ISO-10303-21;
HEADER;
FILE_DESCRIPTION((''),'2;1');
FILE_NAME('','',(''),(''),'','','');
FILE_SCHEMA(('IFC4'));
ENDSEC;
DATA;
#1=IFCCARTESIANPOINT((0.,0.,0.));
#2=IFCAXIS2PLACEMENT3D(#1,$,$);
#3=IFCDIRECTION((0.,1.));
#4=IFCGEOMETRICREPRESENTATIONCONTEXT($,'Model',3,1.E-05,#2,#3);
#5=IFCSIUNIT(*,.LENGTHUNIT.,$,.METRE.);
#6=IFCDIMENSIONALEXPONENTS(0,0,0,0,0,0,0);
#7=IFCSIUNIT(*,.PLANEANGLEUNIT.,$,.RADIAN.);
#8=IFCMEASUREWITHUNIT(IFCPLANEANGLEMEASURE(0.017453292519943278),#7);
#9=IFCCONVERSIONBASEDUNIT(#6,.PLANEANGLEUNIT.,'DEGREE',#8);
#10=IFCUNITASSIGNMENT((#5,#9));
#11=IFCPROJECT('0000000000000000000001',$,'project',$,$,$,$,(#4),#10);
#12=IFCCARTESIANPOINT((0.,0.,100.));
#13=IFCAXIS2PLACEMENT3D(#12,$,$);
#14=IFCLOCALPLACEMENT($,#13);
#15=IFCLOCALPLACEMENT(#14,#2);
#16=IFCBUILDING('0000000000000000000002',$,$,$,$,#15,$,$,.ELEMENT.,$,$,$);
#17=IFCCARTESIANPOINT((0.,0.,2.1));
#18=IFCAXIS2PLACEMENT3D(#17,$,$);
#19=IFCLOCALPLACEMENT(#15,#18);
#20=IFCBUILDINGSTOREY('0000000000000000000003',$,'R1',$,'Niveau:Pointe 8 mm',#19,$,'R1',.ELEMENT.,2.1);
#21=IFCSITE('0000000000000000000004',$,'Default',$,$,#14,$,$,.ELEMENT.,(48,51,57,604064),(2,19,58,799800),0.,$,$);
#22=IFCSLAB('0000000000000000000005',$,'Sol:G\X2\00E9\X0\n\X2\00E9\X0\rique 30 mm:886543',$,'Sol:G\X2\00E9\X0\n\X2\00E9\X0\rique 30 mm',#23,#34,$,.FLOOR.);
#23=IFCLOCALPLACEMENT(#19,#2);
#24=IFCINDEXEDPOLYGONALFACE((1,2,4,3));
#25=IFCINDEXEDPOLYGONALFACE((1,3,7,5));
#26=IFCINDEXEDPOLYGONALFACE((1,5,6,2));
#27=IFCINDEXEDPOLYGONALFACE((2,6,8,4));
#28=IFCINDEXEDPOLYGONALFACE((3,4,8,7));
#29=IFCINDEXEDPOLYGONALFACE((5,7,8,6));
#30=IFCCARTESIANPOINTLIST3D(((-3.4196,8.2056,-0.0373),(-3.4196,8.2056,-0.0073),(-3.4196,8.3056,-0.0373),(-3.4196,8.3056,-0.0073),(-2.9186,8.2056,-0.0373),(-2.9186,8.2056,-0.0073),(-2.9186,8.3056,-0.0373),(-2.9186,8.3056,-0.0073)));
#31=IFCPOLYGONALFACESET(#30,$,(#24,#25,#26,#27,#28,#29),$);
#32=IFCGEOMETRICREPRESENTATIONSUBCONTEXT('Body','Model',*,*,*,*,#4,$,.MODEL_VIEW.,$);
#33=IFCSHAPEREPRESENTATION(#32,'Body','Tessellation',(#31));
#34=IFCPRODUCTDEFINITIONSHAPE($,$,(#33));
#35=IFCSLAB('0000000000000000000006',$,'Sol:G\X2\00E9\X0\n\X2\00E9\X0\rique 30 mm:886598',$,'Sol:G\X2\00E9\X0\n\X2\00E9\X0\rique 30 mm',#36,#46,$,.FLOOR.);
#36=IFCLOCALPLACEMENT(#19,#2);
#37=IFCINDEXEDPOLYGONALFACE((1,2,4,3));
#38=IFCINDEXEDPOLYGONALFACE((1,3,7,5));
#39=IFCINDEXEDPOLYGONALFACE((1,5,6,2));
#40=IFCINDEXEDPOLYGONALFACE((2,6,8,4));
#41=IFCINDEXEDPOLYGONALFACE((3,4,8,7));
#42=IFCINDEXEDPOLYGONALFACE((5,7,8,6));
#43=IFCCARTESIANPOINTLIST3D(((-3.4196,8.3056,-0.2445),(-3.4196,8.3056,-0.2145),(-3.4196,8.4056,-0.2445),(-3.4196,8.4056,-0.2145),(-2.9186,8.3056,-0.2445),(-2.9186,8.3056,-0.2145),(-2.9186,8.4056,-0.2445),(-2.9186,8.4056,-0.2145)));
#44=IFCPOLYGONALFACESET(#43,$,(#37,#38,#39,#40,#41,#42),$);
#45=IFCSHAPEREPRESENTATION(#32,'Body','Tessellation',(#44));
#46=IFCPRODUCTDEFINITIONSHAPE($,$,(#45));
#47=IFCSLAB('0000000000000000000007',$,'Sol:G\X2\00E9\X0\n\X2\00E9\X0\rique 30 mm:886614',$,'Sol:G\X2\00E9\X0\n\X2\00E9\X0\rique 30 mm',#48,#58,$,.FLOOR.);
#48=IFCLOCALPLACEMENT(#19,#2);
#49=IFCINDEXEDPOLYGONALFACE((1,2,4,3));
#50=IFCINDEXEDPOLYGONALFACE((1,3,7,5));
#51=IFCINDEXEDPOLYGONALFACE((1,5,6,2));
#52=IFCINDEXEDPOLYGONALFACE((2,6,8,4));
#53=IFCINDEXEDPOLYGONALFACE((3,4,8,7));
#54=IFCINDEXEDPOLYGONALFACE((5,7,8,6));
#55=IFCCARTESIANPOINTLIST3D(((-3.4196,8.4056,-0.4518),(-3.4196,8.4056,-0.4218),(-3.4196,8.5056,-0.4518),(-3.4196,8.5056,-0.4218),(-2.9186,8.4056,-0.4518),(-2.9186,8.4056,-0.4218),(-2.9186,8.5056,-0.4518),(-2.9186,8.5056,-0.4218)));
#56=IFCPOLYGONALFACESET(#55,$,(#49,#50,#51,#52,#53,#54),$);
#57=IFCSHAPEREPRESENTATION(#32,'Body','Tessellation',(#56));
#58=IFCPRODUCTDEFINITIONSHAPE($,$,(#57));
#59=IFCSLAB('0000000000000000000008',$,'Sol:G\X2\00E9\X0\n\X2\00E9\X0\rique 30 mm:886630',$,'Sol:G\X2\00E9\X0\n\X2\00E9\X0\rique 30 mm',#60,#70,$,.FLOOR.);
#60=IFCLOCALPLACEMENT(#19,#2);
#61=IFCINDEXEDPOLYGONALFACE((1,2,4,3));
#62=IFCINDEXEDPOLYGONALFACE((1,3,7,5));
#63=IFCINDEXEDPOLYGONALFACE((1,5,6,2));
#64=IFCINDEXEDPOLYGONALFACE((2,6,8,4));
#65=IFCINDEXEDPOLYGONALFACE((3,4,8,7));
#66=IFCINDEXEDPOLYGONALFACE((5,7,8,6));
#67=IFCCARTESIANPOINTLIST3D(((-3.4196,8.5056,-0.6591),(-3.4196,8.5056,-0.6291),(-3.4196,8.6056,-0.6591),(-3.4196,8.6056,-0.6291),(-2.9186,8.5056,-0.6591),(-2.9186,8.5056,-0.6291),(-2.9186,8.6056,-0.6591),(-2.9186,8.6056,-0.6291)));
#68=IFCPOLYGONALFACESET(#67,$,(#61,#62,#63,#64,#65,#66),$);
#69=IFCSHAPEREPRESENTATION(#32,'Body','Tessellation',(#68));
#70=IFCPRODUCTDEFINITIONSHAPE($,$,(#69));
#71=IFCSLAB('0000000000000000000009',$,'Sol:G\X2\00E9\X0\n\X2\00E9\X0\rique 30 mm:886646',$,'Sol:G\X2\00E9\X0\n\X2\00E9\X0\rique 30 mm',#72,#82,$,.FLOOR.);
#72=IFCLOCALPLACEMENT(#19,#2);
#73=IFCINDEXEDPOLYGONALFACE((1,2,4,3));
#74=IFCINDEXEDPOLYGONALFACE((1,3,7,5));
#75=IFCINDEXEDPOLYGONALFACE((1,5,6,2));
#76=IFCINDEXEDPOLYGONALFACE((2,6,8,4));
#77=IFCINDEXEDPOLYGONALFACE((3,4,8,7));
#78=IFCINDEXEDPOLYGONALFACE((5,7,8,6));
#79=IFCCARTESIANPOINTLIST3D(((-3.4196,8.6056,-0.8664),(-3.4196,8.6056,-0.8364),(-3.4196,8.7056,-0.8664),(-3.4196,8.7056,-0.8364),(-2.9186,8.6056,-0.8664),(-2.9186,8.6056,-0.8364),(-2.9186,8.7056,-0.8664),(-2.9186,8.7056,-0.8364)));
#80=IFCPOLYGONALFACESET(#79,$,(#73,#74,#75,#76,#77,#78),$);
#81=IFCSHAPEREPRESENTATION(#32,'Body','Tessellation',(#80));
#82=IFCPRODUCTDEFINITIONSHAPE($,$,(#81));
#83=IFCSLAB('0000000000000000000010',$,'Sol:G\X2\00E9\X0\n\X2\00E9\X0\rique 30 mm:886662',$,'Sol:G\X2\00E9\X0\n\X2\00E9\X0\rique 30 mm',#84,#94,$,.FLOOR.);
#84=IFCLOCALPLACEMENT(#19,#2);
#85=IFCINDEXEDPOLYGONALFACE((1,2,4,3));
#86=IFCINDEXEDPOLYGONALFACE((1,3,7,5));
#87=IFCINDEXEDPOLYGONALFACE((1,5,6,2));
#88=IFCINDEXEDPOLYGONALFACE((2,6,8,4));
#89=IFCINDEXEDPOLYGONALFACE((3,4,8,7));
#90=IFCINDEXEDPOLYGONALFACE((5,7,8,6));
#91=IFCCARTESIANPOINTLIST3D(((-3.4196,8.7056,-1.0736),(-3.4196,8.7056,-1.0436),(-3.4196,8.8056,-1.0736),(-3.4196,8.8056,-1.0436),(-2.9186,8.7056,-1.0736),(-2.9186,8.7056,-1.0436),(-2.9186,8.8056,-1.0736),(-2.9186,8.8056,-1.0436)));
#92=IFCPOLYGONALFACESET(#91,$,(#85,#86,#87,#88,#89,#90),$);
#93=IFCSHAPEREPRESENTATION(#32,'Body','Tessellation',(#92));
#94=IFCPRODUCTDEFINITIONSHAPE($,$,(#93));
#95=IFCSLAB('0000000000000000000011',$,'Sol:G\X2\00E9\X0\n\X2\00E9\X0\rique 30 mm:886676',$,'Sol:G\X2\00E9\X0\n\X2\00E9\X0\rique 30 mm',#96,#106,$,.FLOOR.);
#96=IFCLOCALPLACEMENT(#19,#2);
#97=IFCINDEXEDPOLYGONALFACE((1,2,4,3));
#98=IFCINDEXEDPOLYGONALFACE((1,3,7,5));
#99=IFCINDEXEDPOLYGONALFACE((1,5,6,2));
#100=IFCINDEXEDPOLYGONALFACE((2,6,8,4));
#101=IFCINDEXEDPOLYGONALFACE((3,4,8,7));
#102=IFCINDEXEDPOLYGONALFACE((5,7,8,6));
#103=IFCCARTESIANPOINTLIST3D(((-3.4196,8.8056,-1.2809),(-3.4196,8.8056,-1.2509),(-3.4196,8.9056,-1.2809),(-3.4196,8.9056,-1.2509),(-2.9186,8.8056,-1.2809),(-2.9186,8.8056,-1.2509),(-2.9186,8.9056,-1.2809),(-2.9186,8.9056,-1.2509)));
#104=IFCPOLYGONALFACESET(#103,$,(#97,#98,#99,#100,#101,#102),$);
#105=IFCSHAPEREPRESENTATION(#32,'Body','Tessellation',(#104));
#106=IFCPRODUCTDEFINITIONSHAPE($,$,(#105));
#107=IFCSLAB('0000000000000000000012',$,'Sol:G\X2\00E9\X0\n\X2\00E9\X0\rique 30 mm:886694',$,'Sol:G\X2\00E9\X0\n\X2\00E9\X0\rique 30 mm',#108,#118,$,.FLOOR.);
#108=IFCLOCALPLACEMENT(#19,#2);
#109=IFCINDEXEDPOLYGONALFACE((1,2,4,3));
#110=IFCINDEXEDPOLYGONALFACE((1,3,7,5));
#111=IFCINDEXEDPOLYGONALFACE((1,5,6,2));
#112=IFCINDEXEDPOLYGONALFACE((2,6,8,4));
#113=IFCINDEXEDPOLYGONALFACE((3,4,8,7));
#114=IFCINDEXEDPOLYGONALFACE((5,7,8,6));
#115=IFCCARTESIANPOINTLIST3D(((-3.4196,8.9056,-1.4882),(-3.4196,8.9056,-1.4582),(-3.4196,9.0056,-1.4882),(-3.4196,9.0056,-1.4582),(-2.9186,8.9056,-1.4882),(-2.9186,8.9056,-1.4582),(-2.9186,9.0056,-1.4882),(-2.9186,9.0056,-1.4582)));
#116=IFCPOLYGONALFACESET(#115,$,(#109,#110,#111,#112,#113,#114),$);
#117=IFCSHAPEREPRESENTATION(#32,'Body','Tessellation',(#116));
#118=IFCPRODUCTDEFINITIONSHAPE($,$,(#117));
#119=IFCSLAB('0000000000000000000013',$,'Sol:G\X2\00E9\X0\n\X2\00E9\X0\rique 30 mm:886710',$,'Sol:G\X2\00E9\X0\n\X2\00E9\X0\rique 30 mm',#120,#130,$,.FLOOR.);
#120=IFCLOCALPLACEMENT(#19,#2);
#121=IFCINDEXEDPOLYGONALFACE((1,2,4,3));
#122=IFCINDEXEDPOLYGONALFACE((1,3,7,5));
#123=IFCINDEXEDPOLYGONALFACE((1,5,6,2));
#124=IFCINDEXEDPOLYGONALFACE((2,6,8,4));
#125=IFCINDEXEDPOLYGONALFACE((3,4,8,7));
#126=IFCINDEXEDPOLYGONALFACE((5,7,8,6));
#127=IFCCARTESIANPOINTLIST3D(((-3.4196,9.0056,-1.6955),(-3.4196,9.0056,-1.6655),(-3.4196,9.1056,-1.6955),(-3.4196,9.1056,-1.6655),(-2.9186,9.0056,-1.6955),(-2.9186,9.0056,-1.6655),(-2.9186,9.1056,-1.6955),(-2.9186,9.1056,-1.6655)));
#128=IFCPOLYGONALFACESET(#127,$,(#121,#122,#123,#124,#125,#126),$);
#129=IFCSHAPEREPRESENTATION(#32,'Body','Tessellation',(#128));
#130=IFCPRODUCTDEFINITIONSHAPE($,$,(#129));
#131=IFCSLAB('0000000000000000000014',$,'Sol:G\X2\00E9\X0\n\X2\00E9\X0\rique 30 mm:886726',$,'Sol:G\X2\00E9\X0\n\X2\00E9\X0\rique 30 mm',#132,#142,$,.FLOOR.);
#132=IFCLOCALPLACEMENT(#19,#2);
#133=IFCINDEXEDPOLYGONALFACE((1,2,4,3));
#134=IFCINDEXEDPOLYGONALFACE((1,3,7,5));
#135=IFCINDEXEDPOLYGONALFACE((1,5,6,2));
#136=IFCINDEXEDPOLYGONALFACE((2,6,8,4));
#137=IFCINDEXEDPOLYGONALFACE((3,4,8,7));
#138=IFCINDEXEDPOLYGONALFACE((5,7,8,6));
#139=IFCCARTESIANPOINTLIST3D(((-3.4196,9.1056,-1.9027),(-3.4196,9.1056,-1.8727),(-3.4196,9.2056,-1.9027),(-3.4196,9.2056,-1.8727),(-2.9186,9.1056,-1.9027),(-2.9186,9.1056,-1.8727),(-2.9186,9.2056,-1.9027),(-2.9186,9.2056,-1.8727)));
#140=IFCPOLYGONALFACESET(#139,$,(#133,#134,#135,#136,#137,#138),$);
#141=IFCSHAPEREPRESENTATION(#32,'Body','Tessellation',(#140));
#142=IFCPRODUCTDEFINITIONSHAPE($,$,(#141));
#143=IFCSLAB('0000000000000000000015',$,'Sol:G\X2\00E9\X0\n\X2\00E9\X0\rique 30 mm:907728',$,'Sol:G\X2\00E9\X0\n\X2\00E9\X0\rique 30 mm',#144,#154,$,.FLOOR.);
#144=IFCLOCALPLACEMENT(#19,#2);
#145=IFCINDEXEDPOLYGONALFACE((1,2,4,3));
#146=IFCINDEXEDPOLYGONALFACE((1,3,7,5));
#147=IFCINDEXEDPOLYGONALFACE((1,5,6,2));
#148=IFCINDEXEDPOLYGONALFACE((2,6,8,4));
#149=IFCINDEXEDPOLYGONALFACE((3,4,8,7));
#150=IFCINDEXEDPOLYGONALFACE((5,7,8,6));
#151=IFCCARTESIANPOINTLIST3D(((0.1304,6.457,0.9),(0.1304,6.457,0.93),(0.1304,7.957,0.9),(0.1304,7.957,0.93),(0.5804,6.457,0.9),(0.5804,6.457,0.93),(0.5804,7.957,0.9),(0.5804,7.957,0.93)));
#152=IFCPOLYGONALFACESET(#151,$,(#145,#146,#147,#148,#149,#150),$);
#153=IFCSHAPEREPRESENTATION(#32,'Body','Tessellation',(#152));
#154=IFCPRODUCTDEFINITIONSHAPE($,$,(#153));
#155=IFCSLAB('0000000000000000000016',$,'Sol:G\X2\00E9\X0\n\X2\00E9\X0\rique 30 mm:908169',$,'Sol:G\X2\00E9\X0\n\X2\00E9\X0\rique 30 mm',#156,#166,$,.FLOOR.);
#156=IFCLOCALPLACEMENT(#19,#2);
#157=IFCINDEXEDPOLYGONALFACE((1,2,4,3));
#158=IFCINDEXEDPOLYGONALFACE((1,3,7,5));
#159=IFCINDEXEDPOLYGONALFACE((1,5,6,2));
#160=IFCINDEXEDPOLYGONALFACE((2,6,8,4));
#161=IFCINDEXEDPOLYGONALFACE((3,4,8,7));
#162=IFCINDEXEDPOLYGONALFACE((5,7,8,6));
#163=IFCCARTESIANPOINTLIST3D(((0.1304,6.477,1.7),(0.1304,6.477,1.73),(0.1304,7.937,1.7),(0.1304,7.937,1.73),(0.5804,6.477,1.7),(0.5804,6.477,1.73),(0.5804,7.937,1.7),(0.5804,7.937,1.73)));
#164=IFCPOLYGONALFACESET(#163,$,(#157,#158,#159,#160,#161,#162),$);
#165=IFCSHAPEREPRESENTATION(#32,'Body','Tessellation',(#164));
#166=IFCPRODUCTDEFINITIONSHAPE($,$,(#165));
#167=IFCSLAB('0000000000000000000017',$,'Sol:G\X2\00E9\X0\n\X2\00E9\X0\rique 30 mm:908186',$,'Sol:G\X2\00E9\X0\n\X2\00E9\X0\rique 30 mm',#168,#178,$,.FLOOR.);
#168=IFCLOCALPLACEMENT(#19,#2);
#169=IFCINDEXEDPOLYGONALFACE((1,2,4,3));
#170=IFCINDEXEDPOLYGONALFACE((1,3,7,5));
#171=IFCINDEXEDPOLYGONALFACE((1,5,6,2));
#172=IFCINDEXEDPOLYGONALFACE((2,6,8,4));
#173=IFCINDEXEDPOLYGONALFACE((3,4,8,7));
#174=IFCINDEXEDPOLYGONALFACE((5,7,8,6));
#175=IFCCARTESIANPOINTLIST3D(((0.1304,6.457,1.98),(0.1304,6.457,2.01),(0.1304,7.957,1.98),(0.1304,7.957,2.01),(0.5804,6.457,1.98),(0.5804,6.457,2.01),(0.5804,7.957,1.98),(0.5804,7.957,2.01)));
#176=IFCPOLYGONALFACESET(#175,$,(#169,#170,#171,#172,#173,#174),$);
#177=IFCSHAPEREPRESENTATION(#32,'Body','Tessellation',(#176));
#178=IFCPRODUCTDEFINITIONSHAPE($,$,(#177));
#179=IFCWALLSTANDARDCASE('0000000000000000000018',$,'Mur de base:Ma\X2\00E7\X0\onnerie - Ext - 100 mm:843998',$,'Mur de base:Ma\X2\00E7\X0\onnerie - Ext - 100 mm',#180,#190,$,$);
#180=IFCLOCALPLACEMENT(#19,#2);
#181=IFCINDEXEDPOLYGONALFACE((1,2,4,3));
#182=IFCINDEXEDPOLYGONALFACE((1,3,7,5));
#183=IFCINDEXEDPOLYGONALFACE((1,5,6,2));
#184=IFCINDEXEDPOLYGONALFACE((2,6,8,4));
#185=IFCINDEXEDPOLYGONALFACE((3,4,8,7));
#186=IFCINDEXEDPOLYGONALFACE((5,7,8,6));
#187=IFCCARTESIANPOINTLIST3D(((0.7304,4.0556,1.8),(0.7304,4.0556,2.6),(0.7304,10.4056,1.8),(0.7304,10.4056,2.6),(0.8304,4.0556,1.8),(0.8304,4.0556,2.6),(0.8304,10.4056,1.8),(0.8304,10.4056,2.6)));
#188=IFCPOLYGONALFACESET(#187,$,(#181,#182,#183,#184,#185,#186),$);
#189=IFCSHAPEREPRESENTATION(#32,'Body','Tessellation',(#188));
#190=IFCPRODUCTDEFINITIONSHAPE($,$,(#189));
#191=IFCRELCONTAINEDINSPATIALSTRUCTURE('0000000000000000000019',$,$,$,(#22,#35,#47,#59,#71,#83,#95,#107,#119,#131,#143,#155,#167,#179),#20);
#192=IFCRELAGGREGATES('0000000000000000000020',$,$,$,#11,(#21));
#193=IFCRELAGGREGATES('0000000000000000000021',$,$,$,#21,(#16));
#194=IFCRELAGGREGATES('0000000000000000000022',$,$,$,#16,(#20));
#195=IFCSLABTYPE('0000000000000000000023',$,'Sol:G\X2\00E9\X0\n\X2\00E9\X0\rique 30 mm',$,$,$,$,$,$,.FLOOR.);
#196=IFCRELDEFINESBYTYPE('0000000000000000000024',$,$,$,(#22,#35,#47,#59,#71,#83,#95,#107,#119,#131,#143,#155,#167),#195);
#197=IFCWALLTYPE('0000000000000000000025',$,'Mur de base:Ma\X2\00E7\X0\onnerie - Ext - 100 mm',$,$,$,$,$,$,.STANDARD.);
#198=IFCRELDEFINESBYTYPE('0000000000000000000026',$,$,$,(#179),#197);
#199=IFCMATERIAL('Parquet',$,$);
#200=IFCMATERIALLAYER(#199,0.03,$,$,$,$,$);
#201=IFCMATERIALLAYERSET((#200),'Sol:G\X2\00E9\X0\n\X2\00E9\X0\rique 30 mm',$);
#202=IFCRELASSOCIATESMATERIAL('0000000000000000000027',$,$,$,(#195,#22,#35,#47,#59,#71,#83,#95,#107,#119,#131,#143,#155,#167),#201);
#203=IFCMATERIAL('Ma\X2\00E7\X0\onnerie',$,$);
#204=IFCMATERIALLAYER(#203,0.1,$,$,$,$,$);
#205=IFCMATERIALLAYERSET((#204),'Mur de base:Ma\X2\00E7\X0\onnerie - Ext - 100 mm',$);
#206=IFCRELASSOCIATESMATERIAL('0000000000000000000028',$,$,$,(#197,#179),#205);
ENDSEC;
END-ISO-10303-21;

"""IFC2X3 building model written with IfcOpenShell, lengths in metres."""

from ifc_helpers import new_model, entity, si_unit, converted_unit, direction, frame, frame_2d, origin, place, context, subcontext, project, spatial, rectangle, extrude, material, layer, layer_set, layer_usage, type_object, element, save


model = new_model("IFC2X3")

# Units and contexts
model_context = context("Model", 3, precision=1e-05, world=origin(), true_north=direction((0.0, 1.0)))
body_context = subcontext(model_context, "Body", "Model", "MODEL_VIEW")
ifc_project = project(units=[si_unit("LENGTHUNIT", "METRE"), converted_unit("PLANEANGLEUNIT", "DEGREE", entity("IfcPlaneAngleMeasure", 0.017453292519943278), si_unit("PLANEANGLEUNIT", "RADIAN"), dimensions=[0, 0, 0, 0, 0, 0, 0])], contexts=[model_context])

# Site, building, storey
site_placement = place(None, frame((0.0, 0.0, 100.0)))
site = spatial("IfcSite", under=ifc_project, at=site_placement, Name="Default", CompositionType="ELEMENT", RefLatitude=(48, 51, 57, 604064), RefLongitude=(2, 19, 58, 799800), RefElevation=0.0)
building_placement = place(site_placement, origin())
building = spatial("IfcBuilding", under=site, at=building_placement, CompositionType="ELEMENT")
storey_placement = place(building_placement, frame((0.0, 0.0, 2.1)))
storey = spatial("IfcBuildingStorey", under=building, at=storey_placement, Name="R1", ObjectType="Niveau:Pointe 8 mm", LongName="R1", CompositionType="ELEMENT", Elevation=2.1)

# Shared definitions
ifc_material_1 = material(Name="Parquet")

# Slabs
ifc_layer_1 = layer(ifc_material_1, 0.03)
ifc_layer_set_1 = layer_set([ifc_layer_1], Name="Sol:Générique 30 mm")
ifc_layer_usage_1 = layer_usage(ifc_layer_set_1, "AXIS3", "POSITIVE", 0.0)
slab_type = type_object("IfcSlabType", Name="Sol:Générique 30 mm", PredefinedType="FLOOR", material=ifc_layer_set_1)
slab_1_placement = place(storey_placement, origin())
element("IfcSlab", 1, at=slab_1_placement, inside=storey, type_object=slab_type, material=ifc_layer_usage_1, Name="Sol:Générique 30 mm:886543", ObjectType="Sol:Générique 30 mm", PredefinedType="FLOOR", context=body_context, shape_type="SweptSolid", body=[
    extrude(rectangle(XDim=0.1, YDim=0.501, at=frame_2d((0.0, 0.0), x_axis=(1.0, 0.0))), frame((-3.1691, 8.2556, -0.0073), z_axis=(0.0, 0.0, -1.0), x_axis=(0.0, 1.0, 0.0)), (0.0, 0.0, 1.0), 0.03),
])
ifc_layer_usage_2 = layer_usage(ifc_layer_set_1, "AXIS3", "POSITIVE", 0.0)
slab_2_placement = place(storey_placement, origin())
element("IfcSlab", 2, at=slab_2_placement, inside=storey, type_object=slab_type, material=ifc_layer_usage_2, Name="Sol:Générique 30 mm:886598", ObjectType="Sol:Générique 30 mm", PredefinedType="FLOOR", context=body_context, shape_type="SweptSolid", body=[
    extrude(rectangle(XDim=0.1, YDim=0.501, at=frame_2d((0.0, 0.0), x_axis=(1.0, 0.0))), frame((-3.1691, 8.3556, -0.2145), z_axis=(0.0, 0.0, -1.0), x_axis=(0.0, 1.0, 0.0)), (0.0, 0.0, 1.0), 0.03),
])
ifc_layer_usage_3 = layer_usage(ifc_layer_set_1, "AXIS3", "POSITIVE", 0.0)
slab_3_placement = place(storey_placement, origin())
element("IfcSlab", 3, at=slab_3_placement, inside=storey, type_object=slab_type, material=ifc_layer_usage_3, Name="Sol:Générique 30 mm:886614", ObjectType="Sol:Générique 30 mm", PredefinedType="FLOOR", context=body_context, shape_type="SweptSolid", body=[
    extrude(rectangle(XDim=0.1, YDim=0.501, at=frame_2d((0.0, 0.0), x_axis=(1.0, 0.0))), frame((-3.1691, 8.4556, -0.4218), z_axis=(0.0, 0.0, -1.0), x_axis=(0.0, 1.0, 0.0)), (0.0, 0.0, 1.0), 0.03),
])
ifc_layer_usage_4 = layer_usage(ifc_layer_set_1, "AXIS3", "POSITIVE", 0.0)
slab_4_placement = place(storey_placement, origin())
element("IfcSlab", 4, at=slab_4_placement, inside=storey, type_object=slab_type, material=ifc_layer_usage_4, Name="Sol:Générique 30 mm:886630", ObjectType="Sol:Générique 30 mm", PredefinedType="FLOOR", context=body_context, shape_type="SweptSolid", body=[
    extrude(rectangle(XDim=0.1, YDim=0.501, at=frame_2d((0.0, 0.0), x_axis=(1.0, 0.0))), frame((-3.1691, 8.5556, -0.6291), z_axis=(0.0, 0.0, -1.0), x_axis=(0.0, 1.0, 0.0)), (0.0, 0.0, 1.0), 0.03),
])
ifc_layer_usage_5 = layer_usage(ifc_layer_set_1, "AXIS3", "POSITIVE", 0.0)
slab_5_placement = place(storey_placement, origin())
element("IfcSlab", 5, at=slab_5_placement, inside=storey, type_object=slab_type, material=ifc_layer_usage_5, Name="Sol:Générique 30 mm:886646", ObjectType="Sol:Générique 30 mm", PredefinedType="FLOOR", context=body_context, shape_type="SweptSolid", body=[
    extrude(rectangle(XDim=0.1, YDim=0.501, at=frame_2d((0.0, 0.0), x_axis=(1.0, 0.0))), frame((-3.1691, 8.6556, -0.8364), z_axis=(0.0, 0.0, -1.0), x_axis=(0.0, 1.0, 0.0)), (0.0, 0.0, 1.0), 0.03),
])
ifc_layer_usage_6 = layer_usage(ifc_layer_set_1, "AXIS3", "POSITIVE", 0.0)
slab_6_placement = place(storey_placement, origin())
element("IfcSlab", 6, at=slab_6_placement, inside=storey, type_object=slab_type, material=ifc_layer_usage_6, Name="Sol:Générique 30 mm:886662", ObjectType="Sol:Générique 30 mm", PredefinedType="FLOOR", context=body_context, shape_type="SweptSolid", body=[
    extrude(rectangle(XDim=0.1, YDim=0.501, at=frame_2d((0.0, 0.0), x_axis=(1.0, 0.0))), frame((-3.1691, 8.7556, -1.0436), z_axis=(0.0, 0.0, -1.0), x_axis=(0.0, 1.0, 0.0)), (0.0, 0.0, 1.0), 0.03),
])
ifc_layer_usage_7 = layer_usage(ifc_layer_set_1, "AXIS3", "POSITIVE", 0.0)
slab_7_placement = place(storey_placement, origin())
element("IfcSlab", 7, at=slab_7_placement, inside=storey, type_object=slab_type, material=ifc_layer_usage_7, Name="Sol:Générique 30 mm:886676", ObjectType="Sol:Générique 30 mm", PredefinedType="FLOOR", context=body_context, shape_type="SweptSolid", body=[
    extrude(rectangle(XDim=0.1, YDim=0.501, at=frame_2d((0.0, 0.0), x_axis=(1.0, 0.0))), frame((-3.1691, 8.8556, -1.2509), z_axis=(0.0, 0.0, -1.0), x_axis=(0.0, 1.0, 0.0)), (0.0, 0.0, 1.0), 0.03),
])
ifc_layer_usage_8 = layer_usage(ifc_layer_set_1, "AXIS3", "POSITIVE", 0.0)
slab_8_placement = place(storey_placement, origin())
element("IfcSlab", 8, at=slab_8_placement, inside=storey, type_object=slab_type, material=ifc_layer_usage_8, Name="Sol:Générique 30 mm:886694", ObjectType="Sol:Générique 30 mm", PredefinedType="FLOOR", context=body_context, shape_type="SweptSolid", body=[
    extrude(rectangle(XDim=0.1, YDim=0.501, at=frame_2d((0.0, 0.0), x_axis=(1.0, 0.0))), frame((-3.1691, 8.9556, -1.4582), z_axis=(0.0, 0.0, -1.0), x_axis=(0.0, 1.0, 0.0)), (0.0, 0.0, 1.0), 0.03),
])
ifc_layer_usage_9 = layer_usage(ifc_layer_set_1, "AXIS3", "POSITIVE", 0.0)
slab_9_placement = place(storey_placement, origin())
element("IfcSlab", 9, at=slab_9_placement, inside=storey, type_object=slab_type, material=ifc_layer_usage_9, Name="Sol:Générique 30 mm:886710", ObjectType="Sol:Générique 30 mm", PredefinedType="FLOOR", context=body_context, shape_type="SweptSolid", body=[
    extrude(rectangle(XDim=0.1, YDim=0.501, at=frame_2d((0.0, 0.0), x_axis=(1.0, 0.0))), frame((-3.1691, 9.0556, -1.6655), z_axis=(0.0, 0.0, -1.0), x_axis=(0.0, 1.0, 0.0)), (0.0, 0.0, 1.0), 0.03),
])
ifc_layer_usage_10 = layer_usage(ifc_layer_set_1, "AXIS3", "POSITIVE", 0.0)
slab_10_placement = place(storey_placement, origin())
element("IfcSlab", 10, at=slab_10_placement, inside=storey, type_object=slab_type, material=ifc_layer_usage_10, Name="Sol:Générique 30 mm:886726", ObjectType="Sol:Générique 30 mm", PredefinedType="FLOOR", context=body_context, shape_type="SweptSolid", body=[
    extrude(rectangle(XDim=0.1, YDim=0.501, at=frame_2d((0.0, 0.0), x_axis=(1.0, 0.0))), frame((-3.1691, 9.1556, -1.8727), z_axis=(0.0, 0.0, -1.0), x_axis=(0.0, 1.0, 0.0)), (0.0, 0.0, 1.0), 0.03),
])
ifc_layer_usage_11 = layer_usage(ifc_layer_set_1, "AXIS3", "POSITIVE", 0.0)
slab_11_placement = place(storey_placement, origin())
element("IfcSlab", 11, at=slab_11_placement, inside=storey, type_object=slab_type, material=ifc_layer_usage_11, Name="Sol:Générique 30 mm:907728", ObjectType="Sol:Générique 30 mm", PredefinedType="FLOOR", context=body_context, shape_type="SweptSolid", body=[
    extrude(rectangle(XDim=1.5, YDim=0.45, at=frame_2d((0.0, 0.0), x_axis=(1.0, 0.0))), frame((0.3554, 7.207, 0.93), z_axis=(0.0, 0.0, -1.0), x_axis=(0.0, 1.0, 0.0)), (0.0, 0.0, 1.0), 0.03),
])
ifc_layer_usage_12 = layer_usage(ifc_layer_set_1, "AXIS3", "POSITIVE", 0.0)
slab_12_placement = place(storey_placement, origin())
element("IfcSlab", 12, at=slab_12_placement, inside=storey, type_object=slab_type, material=ifc_layer_usage_12, Name="Sol:Générique 30 mm:908169", ObjectType="Sol:Générique 30 mm", PredefinedType="FLOOR", context=body_context, shape_type="SweptSolid", body=[
    extrude(rectangle(XDim=1.46, YDim=0.45, at=frame_2d((0.0, 0.0), x_axis=(1.0, 0.0))), frame((0.3554, 7.207, 1.73), z_axis=(0.0, 0.0, -1.0), x_axis=(0.0, 1.0, 0.0)), (0.0, 0.0, 1.0), 0.03),
])
ifc_layer_usage_13 = layer_usage(ifc_layer_set_1, "AXIS3", "POSITIVE", 0.0)
slab_13_placement = place(storey_placement, origin())
element("IfcSlab", 13, at=slab_13_placement, inside=storey, type_object=slab_type, material=ifc_layer_usage_13, Name="Sol:Générique 30 mm:908186", ObjectType="Sol:Générique 30 mm", PredefinedType="FLOOR", context=body_context, shape_type="SweptSolid", body=[
    extrude(rectangle(XDim=1.5, YDim=0.45, at=frame_2d((0.0, 0.0), x_axis=(1.0, 0.0))), frame((0.3554, 7.207, 2.01), z_axis=(0.0, 0.0, -1.0), x_axis=(0.0, 1.0, 0.0)), (0.0, 0.0, 1.0), 0.03),
])

# Wall
ifc_material_2 = material(Name="Maçonnerie")
ifc_layer_2 = layer(ifc_material_2, 0.1)
ifc_layer_set_2 = layer_set([ifc_layer_2], Name="Mur de base:Maçonnerie - Ext - 100 mm")
ifc_layer_usage_14 = layer_usage(ifc_layer_set_2, "AXIS2", "NEGATIVE", 0.05)
wall_type = type_object("IfcWallType", Name="Mur de base:Maçonnerie - Ext - 100 mm", PredefinedType="STANDARD", material=ifc_layer_set_2)
wall_1_placement = place(storey_placement, frame((0.7804, 4.0556, 1.8), z_axis=(0.0, 0.0, 1.0), x_axis=(0.0, 1.0, 0.0)))
element("IfcWallStandardCase", 14, at=wall_1_placement, inside=storey, type_object=wall_type, material=ifc_layer_usage_14, Name="Mur de base:Maçonnerie - Ext - 100 mm:843998", ObjectType="Mur de base:Maçonnerie - Ext - 100 mm", context=body_context, shape_type="SweptSolid", body=[
    extrude(rectangle(XDim=6.35, YDim=0.1, at=frame_2d((3.175, 0.0), x_axis=(-1.0, 0.0))), origin(), (0.0, 0.0, 1.0), 0.8),
])

save(model, "model.ifc")
